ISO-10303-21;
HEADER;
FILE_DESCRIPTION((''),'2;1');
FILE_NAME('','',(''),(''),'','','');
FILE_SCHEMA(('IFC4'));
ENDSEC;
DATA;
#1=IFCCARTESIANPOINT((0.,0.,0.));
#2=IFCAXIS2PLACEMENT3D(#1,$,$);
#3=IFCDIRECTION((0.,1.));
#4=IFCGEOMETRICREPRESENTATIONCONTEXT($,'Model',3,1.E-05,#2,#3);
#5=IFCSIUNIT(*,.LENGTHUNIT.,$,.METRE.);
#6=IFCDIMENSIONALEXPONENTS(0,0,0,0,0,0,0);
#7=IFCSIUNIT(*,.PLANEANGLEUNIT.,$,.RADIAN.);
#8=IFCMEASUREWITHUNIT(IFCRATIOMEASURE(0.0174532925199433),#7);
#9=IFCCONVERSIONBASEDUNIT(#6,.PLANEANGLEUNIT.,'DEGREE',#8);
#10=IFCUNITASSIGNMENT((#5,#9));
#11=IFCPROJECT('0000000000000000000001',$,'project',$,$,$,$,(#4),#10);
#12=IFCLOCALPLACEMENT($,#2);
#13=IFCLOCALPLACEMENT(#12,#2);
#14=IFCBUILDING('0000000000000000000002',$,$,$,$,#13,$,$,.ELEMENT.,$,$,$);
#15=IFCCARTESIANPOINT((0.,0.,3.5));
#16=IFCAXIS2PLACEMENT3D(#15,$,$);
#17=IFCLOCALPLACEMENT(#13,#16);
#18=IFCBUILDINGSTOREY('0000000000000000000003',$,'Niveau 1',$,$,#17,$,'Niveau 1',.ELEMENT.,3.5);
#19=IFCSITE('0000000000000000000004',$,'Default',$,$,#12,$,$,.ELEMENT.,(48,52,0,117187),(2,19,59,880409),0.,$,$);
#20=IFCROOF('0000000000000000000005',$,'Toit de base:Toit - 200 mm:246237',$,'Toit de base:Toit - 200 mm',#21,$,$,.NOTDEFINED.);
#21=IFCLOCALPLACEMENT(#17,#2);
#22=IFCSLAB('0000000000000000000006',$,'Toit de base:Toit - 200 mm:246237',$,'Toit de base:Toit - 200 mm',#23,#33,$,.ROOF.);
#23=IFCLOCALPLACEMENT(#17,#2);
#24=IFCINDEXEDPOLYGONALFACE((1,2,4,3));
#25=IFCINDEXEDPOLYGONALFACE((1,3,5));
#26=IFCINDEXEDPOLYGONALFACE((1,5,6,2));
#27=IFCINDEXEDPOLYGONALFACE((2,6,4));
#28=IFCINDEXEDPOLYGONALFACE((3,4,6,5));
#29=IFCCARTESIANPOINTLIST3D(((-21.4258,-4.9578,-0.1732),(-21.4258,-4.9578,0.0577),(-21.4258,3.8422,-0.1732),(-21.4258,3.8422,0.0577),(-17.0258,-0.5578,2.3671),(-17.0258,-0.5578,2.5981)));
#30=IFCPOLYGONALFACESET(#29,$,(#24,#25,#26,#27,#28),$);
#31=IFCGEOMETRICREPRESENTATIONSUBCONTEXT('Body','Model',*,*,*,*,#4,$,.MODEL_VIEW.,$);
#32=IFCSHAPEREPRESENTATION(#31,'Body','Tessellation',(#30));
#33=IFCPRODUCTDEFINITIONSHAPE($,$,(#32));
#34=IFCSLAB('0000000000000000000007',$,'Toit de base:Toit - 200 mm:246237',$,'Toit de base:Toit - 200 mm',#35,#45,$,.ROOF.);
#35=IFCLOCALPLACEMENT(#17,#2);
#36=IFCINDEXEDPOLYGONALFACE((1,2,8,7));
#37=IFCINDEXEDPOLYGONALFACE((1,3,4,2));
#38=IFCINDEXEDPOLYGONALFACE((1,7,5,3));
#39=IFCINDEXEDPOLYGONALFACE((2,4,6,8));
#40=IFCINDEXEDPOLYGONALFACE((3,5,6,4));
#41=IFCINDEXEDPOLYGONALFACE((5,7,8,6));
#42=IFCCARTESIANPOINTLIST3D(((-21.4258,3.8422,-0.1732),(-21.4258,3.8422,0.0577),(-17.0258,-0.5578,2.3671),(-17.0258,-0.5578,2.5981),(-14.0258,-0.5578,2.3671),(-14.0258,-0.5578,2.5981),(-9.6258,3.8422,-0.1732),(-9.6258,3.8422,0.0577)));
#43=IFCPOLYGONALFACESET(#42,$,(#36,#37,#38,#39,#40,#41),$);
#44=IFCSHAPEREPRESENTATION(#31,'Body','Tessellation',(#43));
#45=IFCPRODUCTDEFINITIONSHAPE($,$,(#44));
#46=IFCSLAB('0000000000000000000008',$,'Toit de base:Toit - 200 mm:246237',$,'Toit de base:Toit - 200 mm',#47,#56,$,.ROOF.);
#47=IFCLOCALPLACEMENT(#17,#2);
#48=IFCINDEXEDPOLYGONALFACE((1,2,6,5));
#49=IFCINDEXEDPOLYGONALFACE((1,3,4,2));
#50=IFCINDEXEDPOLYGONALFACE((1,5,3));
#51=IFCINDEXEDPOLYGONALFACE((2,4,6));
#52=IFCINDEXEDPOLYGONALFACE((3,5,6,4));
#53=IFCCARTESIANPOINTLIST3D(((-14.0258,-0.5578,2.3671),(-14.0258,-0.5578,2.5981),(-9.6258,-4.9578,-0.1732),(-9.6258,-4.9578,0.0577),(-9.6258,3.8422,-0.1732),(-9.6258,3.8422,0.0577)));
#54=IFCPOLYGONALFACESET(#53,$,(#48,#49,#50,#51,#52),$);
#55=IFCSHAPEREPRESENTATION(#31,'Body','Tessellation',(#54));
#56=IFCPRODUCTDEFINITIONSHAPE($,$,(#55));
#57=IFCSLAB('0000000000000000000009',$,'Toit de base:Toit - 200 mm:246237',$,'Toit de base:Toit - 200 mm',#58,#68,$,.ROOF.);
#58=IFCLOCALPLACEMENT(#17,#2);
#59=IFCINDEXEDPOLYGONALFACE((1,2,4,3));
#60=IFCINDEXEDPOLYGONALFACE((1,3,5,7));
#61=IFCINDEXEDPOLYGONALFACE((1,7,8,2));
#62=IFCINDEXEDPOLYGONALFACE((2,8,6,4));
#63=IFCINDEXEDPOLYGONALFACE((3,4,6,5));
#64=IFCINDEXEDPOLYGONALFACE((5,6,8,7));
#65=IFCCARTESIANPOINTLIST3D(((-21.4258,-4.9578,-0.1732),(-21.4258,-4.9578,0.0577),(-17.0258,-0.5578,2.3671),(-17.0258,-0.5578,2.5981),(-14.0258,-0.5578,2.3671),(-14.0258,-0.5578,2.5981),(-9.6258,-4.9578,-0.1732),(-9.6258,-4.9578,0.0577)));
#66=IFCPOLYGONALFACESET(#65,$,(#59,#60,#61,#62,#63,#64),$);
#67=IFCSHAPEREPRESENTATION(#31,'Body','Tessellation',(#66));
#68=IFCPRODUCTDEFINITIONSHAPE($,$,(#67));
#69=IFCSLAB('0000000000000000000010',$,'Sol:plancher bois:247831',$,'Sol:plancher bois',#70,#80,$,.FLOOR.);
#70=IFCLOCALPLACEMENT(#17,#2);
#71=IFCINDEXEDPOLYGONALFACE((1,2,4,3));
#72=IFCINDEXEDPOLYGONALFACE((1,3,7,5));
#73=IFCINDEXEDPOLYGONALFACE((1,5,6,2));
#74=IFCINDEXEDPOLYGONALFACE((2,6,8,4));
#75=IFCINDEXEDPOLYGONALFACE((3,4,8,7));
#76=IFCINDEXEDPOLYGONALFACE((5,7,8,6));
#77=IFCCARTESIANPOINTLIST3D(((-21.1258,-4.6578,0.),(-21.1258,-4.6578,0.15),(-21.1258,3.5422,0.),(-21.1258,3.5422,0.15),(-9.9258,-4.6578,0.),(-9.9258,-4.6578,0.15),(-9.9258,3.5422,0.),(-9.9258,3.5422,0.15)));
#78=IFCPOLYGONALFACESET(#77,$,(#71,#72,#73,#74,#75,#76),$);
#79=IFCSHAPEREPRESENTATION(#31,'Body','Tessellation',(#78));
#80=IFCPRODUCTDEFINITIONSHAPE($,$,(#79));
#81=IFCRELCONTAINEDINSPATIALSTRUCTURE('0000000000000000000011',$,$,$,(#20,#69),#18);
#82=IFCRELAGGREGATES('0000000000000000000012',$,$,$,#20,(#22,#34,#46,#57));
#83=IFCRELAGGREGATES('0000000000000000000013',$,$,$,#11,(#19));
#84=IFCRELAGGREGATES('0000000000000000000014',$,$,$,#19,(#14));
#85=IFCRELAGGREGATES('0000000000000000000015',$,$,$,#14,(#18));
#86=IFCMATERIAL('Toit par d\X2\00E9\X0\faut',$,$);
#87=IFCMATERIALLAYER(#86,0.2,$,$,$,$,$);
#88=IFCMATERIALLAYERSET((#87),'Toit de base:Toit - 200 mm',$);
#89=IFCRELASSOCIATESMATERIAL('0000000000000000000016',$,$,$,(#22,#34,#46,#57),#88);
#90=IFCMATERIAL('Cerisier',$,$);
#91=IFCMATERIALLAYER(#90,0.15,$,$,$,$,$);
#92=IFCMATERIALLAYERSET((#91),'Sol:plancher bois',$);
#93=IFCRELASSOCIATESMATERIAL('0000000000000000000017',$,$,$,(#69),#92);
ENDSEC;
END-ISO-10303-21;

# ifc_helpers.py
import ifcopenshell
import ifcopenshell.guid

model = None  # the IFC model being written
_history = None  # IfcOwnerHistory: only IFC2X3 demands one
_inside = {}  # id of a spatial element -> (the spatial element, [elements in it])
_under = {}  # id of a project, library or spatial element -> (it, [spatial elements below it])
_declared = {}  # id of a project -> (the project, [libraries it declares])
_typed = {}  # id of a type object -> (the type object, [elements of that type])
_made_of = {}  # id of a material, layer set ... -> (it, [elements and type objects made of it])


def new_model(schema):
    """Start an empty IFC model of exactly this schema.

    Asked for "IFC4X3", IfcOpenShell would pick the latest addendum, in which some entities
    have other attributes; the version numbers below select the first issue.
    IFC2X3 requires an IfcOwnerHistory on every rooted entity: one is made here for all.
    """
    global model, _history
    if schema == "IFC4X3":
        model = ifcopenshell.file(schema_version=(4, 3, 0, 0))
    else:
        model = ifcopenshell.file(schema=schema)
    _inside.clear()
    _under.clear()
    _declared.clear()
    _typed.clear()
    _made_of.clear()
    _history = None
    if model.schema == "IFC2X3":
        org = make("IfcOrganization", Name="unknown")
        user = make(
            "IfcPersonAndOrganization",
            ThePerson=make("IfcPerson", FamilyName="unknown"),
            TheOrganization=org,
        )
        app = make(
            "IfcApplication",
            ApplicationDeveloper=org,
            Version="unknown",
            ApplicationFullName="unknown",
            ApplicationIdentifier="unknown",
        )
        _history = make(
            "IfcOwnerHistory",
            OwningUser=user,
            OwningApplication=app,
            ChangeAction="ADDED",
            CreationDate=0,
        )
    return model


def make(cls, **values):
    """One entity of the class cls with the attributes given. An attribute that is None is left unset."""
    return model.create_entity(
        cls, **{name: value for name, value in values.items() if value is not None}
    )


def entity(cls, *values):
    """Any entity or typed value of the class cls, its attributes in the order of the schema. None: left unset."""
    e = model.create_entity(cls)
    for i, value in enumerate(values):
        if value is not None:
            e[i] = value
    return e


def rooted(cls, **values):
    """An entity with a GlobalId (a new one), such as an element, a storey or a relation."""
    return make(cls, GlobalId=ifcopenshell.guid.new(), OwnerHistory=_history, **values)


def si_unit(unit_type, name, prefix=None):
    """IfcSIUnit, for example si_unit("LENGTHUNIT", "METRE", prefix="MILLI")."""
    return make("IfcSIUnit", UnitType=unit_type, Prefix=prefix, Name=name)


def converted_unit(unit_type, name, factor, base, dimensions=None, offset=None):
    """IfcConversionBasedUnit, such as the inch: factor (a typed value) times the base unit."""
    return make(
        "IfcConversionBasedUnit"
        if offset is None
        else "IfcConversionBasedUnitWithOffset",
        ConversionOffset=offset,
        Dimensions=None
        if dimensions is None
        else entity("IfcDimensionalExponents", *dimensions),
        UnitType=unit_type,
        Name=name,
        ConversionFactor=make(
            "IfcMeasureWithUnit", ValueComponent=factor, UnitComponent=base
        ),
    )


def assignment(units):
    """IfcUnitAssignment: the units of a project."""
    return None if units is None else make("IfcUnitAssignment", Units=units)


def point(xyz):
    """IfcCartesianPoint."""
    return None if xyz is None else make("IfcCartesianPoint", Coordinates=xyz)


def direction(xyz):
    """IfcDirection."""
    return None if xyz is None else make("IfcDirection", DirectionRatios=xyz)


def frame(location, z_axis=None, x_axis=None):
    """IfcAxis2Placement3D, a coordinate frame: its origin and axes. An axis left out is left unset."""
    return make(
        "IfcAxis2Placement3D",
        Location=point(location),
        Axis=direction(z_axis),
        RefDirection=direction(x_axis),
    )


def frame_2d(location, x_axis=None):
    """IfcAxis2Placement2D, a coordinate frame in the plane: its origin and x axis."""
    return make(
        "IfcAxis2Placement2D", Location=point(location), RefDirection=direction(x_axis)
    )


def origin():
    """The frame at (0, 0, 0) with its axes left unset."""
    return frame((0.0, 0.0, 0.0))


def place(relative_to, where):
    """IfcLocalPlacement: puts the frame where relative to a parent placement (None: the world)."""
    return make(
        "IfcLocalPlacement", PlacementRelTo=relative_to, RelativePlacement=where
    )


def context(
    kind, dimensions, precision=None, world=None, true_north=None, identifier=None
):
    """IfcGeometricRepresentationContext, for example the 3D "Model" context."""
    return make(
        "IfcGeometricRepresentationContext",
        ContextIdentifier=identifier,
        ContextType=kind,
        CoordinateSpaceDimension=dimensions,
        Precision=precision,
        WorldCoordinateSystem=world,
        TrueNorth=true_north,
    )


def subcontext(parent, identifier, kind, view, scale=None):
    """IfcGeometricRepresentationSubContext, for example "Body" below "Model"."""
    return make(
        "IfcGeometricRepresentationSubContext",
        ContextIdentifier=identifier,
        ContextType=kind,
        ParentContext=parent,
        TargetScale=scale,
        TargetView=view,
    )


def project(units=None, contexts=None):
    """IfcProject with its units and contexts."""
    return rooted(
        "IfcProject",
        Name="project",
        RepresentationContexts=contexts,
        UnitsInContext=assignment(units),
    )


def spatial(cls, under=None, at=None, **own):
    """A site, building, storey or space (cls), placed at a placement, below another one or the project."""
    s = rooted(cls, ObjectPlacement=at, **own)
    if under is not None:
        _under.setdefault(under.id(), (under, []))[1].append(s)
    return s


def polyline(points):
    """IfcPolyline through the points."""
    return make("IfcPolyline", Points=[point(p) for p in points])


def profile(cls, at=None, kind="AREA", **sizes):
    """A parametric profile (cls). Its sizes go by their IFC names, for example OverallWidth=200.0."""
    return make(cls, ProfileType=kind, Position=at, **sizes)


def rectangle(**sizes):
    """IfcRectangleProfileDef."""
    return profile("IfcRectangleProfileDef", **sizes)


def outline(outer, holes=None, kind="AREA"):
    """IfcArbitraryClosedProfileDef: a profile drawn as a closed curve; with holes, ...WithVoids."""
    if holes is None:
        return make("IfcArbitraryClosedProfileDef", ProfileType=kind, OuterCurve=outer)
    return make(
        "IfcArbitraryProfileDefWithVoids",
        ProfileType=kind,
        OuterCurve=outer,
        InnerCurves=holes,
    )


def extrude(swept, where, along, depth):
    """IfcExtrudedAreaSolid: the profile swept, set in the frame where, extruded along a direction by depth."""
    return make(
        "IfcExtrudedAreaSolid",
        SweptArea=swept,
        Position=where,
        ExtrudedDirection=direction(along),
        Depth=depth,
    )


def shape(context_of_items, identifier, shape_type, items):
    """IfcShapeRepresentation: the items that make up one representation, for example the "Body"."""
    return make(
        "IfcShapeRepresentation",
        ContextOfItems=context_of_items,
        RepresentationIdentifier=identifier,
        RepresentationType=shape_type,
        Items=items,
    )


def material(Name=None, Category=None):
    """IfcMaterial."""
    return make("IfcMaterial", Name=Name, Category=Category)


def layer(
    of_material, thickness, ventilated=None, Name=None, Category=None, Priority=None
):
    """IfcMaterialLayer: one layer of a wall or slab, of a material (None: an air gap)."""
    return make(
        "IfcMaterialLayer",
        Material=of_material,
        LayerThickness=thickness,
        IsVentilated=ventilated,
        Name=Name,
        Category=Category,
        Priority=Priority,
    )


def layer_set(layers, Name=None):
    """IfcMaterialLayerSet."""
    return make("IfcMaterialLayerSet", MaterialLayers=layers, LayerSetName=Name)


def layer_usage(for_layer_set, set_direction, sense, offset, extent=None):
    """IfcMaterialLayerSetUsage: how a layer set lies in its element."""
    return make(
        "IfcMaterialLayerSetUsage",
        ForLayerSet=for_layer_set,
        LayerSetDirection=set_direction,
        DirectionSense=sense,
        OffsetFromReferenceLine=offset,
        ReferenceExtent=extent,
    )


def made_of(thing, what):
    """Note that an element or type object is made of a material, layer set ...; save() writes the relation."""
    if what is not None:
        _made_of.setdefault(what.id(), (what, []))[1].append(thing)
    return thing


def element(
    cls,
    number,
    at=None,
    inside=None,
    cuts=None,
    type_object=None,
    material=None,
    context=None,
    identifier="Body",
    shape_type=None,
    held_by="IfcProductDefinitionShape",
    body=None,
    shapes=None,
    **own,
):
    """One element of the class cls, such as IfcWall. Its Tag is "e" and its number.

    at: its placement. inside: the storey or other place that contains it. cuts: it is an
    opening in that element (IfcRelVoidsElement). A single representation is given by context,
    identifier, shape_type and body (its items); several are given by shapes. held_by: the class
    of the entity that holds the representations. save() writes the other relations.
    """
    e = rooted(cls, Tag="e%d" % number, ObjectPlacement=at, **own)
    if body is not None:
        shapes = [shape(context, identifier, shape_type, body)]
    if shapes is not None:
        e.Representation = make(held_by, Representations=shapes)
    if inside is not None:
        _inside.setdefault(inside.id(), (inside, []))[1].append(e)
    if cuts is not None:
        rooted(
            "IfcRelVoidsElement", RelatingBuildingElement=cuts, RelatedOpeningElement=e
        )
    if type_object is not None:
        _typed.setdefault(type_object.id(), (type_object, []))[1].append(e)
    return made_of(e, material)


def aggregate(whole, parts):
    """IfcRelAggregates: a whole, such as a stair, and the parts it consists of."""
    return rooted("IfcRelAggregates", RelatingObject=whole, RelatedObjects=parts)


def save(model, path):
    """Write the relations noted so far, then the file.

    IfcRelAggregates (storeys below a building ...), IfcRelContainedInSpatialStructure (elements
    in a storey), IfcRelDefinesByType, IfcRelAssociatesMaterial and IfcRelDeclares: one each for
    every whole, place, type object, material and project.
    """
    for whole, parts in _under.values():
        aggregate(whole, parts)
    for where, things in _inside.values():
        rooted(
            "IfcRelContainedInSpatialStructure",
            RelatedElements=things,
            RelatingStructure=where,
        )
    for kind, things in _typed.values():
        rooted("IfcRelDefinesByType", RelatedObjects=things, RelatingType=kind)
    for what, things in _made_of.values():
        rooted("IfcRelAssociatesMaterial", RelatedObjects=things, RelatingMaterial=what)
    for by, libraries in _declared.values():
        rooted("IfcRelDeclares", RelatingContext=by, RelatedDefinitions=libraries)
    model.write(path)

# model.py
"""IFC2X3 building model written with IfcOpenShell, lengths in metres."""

from ifc_helpers import new_model, entity, si_unit, converted_unit, direction, frame, frame_2d, origin, place, context, subcontext, project, spatial, polyline, rectangle, outline, extrude, material, layer, layer_set, layer_usage, element, aggregate, save


model = new_model("IFC2X3")

# Units and contexts
model_context = context("Model", 3, precision=1e-05, world=origin(), true_north=direction((0.0, 1.0)))
body_context = subcontext(model_context, "Body", "Model", "MODEL_VIEW")
ifc_project = project(units=[si_unit("LENGTHUNIT", "METRE"), converted_unit("PLANEANGLEUNIT", "DEGREE", entity("IfcRatioMeasure", 0.0174532925199433), si_unit("PLANEANGLEUNIT", "RADIAN"), dimensions=[0, 0, 0, 0, 0, 0, 0])], contexts=[model_context])

# Site, building, storey
site_placement = place(None, origin())
site = spatial("IfcSite", under=ifc_project, at=site_placement, Name="Default", CompositionType="ELEMENT", RefLatitude=(48, 52, 0, 117187), RefLongitude=(2, 19, 59, 880409), RefElevation=0.0)
building_placement = place(site_placement, origin())
building = spatial("IfcBuilding", under=site, at=building_placement, CompositionType="ELEMENT")
storey_placement = place(building_placement, frame((0.0, 0.0, 3.5)))
storey = spatial("IfcBuildingStorey", under=building, at=storey_placement, Name="Niveau 1", LongName="Niveau 1", CompositionType="ELEMENT", Elevation=3.5)

# Roof, slabs
roof_placement = place(storey_placement, frame((-21.4258, -4.9578, -0.1732)))
roof = element("IfcRoof", 1, at=roof_placement, inside=storey, Name="Toit de base:Toit - 200 mm:246237", ObjectType="Toit de base:Toit - 200 mm", ShapeType="NOTDEFINED")
ifc_material_1 = material(Name="Toit par défaut")
ifc_layer_1 = layer(ifc_material_1, 0.2)
ifc_layer_set_1 = layer_set([ifc_layer_1], Name="Toit de base:Toit - 200 mm")
slab_1_placement = place(roof_placement, origin())
slab_1 = element("IfcSlab", 2, at=slab_1_placement, material=ifc_layer_set_1, Name="Toit de base:Toit - 200 mm:246237", ObjectType="Toit de base:Toit - 200 mm", PredefinedType="ROOF", context=body_context, shape_type="SweptSolid", body=[
    extrude(outline(polyline([(-2.5403, 4.4), (-2.5403, -4.4), (2.5403, 0.0), (-2.5403, 4.4)])), frame((2.2, 4.4, 1.2702), z_axis=(-0.5, 0.0, 0.866025), x_axis=(0.866025, 0.0, 0.5)), (0.5, 0.0, 0.866025), 0.2309),
])
slab_2_placement = place(roof_placement, origin())
slab_2 = element("IfcSlab", 3, at=slab_2_placement, material=ifc_layer_set_1, Name="Toit de base:Toit - 200 mm:246237", ObjectType="Toit de base:Toit - 200 mm", PredefinedType="ROOF", context=body_context, shape_type="SweptSolid", body=[
    extrude(outline(polyline([(-1.5, -2.5403), (1.5, -2.5403), (5.9, 2.5403), (-5.9, 2.5403), (-1.5, -2.5403)])), frame((5.9, 6.6, 1.2702), z_axis=(0.0, 0.5, 0.866025), x_axis=(1.0, 0.0, 0.0)), (0.0, -0.5, 0.866025), 0.2309),
])
slab_3_placement = place(roof_placement, origin())
slab_3 = element("IfcSlab", 4, at=slab_3_placement, material=ifc_layer_set_1, Name="Toit de base:Toit - 200 mm:246237", ObjectType="Toit de base:Toit - 200 mm", PredefinedType="ROOF", context=body_context, shape_type="SweptSolid", body=[
    extrude(outline(polyline([(2.5403, -4.4), (2.5403, 4.4), (-2.5403, 0.0), (2.5403, -4.4)])), frame((9.6, 4.4, 1.2702), z_axis=(0.5, 0.0, 0.866025), x_axis=(0.866025, 0.0, -0.5)), (-0.5, 0.0, 0.866025), 0.2309),
])
slab_4_placement = place(roof_placement, origin())
slab_4 = element("IfcSlab", 5, at=slab_4_placement, material=ifc_layer_set_1, Name="Toit de base:Toit - 200 mm:246237", ObjectType="Toit de base:Toit - 200 mm", PredefinedType="ROOF", context=body_context, shape_type="SweptSolid", body=[
    extrude(outline(polyline([(-5.9, -2.5403), (5.9, -2.5403), (1.5, 2.5403), (-1.5, 2.5403), (-5.9, -2.5403)])), frame((5.9, 2.2, 1.2702), z_axis=(0.0, -0.5, 0.866025), x_axis=(1.0, 0.0, 0.0)), (0.0, 0.5, 0.866025), 0.2309),
])
aggregate(roof, [slab_1, slab_2, slab_3, slab_4])

# Slab
ifc_material_2 = material(Name="Cerisier")
ifc_layer_2 = layer(ifc_material_2, 0.15)
ifc_layer_set_2 = layer_set([ifc_layer_2], Name="Sol:plancher bois")
ifc_layer_usage = layer_usage(ifc_layer_set_2, "AXIS3", "POSITIVE", 0.0)
slab_5_placement = place(storey_placement, origin())
element("IfcSlab", 6, at=slab_5_placement, inside=storey, material=ifc_layer_usage, Name="Sol:plancher bois:247831", ObjectType="Sol:plancher bois", PredefinedType="FLOOR", context=body_context, shape_type="SweptSolid", body=[
    extrude(rectangle(XDim=8.2, YDim=11.2, at=frame_2d((0.0, 0.0), x_axis=(1.0, 0.0))), frame((-15.5258, -0.5578, 0.15), z_axis=(0.0, 0.0, -1.0), x_axis=(0.0, 1.0, 0.0)), (0.0, 0.0, 1.0), 0.15),
])

save(model, "model.ifc")
